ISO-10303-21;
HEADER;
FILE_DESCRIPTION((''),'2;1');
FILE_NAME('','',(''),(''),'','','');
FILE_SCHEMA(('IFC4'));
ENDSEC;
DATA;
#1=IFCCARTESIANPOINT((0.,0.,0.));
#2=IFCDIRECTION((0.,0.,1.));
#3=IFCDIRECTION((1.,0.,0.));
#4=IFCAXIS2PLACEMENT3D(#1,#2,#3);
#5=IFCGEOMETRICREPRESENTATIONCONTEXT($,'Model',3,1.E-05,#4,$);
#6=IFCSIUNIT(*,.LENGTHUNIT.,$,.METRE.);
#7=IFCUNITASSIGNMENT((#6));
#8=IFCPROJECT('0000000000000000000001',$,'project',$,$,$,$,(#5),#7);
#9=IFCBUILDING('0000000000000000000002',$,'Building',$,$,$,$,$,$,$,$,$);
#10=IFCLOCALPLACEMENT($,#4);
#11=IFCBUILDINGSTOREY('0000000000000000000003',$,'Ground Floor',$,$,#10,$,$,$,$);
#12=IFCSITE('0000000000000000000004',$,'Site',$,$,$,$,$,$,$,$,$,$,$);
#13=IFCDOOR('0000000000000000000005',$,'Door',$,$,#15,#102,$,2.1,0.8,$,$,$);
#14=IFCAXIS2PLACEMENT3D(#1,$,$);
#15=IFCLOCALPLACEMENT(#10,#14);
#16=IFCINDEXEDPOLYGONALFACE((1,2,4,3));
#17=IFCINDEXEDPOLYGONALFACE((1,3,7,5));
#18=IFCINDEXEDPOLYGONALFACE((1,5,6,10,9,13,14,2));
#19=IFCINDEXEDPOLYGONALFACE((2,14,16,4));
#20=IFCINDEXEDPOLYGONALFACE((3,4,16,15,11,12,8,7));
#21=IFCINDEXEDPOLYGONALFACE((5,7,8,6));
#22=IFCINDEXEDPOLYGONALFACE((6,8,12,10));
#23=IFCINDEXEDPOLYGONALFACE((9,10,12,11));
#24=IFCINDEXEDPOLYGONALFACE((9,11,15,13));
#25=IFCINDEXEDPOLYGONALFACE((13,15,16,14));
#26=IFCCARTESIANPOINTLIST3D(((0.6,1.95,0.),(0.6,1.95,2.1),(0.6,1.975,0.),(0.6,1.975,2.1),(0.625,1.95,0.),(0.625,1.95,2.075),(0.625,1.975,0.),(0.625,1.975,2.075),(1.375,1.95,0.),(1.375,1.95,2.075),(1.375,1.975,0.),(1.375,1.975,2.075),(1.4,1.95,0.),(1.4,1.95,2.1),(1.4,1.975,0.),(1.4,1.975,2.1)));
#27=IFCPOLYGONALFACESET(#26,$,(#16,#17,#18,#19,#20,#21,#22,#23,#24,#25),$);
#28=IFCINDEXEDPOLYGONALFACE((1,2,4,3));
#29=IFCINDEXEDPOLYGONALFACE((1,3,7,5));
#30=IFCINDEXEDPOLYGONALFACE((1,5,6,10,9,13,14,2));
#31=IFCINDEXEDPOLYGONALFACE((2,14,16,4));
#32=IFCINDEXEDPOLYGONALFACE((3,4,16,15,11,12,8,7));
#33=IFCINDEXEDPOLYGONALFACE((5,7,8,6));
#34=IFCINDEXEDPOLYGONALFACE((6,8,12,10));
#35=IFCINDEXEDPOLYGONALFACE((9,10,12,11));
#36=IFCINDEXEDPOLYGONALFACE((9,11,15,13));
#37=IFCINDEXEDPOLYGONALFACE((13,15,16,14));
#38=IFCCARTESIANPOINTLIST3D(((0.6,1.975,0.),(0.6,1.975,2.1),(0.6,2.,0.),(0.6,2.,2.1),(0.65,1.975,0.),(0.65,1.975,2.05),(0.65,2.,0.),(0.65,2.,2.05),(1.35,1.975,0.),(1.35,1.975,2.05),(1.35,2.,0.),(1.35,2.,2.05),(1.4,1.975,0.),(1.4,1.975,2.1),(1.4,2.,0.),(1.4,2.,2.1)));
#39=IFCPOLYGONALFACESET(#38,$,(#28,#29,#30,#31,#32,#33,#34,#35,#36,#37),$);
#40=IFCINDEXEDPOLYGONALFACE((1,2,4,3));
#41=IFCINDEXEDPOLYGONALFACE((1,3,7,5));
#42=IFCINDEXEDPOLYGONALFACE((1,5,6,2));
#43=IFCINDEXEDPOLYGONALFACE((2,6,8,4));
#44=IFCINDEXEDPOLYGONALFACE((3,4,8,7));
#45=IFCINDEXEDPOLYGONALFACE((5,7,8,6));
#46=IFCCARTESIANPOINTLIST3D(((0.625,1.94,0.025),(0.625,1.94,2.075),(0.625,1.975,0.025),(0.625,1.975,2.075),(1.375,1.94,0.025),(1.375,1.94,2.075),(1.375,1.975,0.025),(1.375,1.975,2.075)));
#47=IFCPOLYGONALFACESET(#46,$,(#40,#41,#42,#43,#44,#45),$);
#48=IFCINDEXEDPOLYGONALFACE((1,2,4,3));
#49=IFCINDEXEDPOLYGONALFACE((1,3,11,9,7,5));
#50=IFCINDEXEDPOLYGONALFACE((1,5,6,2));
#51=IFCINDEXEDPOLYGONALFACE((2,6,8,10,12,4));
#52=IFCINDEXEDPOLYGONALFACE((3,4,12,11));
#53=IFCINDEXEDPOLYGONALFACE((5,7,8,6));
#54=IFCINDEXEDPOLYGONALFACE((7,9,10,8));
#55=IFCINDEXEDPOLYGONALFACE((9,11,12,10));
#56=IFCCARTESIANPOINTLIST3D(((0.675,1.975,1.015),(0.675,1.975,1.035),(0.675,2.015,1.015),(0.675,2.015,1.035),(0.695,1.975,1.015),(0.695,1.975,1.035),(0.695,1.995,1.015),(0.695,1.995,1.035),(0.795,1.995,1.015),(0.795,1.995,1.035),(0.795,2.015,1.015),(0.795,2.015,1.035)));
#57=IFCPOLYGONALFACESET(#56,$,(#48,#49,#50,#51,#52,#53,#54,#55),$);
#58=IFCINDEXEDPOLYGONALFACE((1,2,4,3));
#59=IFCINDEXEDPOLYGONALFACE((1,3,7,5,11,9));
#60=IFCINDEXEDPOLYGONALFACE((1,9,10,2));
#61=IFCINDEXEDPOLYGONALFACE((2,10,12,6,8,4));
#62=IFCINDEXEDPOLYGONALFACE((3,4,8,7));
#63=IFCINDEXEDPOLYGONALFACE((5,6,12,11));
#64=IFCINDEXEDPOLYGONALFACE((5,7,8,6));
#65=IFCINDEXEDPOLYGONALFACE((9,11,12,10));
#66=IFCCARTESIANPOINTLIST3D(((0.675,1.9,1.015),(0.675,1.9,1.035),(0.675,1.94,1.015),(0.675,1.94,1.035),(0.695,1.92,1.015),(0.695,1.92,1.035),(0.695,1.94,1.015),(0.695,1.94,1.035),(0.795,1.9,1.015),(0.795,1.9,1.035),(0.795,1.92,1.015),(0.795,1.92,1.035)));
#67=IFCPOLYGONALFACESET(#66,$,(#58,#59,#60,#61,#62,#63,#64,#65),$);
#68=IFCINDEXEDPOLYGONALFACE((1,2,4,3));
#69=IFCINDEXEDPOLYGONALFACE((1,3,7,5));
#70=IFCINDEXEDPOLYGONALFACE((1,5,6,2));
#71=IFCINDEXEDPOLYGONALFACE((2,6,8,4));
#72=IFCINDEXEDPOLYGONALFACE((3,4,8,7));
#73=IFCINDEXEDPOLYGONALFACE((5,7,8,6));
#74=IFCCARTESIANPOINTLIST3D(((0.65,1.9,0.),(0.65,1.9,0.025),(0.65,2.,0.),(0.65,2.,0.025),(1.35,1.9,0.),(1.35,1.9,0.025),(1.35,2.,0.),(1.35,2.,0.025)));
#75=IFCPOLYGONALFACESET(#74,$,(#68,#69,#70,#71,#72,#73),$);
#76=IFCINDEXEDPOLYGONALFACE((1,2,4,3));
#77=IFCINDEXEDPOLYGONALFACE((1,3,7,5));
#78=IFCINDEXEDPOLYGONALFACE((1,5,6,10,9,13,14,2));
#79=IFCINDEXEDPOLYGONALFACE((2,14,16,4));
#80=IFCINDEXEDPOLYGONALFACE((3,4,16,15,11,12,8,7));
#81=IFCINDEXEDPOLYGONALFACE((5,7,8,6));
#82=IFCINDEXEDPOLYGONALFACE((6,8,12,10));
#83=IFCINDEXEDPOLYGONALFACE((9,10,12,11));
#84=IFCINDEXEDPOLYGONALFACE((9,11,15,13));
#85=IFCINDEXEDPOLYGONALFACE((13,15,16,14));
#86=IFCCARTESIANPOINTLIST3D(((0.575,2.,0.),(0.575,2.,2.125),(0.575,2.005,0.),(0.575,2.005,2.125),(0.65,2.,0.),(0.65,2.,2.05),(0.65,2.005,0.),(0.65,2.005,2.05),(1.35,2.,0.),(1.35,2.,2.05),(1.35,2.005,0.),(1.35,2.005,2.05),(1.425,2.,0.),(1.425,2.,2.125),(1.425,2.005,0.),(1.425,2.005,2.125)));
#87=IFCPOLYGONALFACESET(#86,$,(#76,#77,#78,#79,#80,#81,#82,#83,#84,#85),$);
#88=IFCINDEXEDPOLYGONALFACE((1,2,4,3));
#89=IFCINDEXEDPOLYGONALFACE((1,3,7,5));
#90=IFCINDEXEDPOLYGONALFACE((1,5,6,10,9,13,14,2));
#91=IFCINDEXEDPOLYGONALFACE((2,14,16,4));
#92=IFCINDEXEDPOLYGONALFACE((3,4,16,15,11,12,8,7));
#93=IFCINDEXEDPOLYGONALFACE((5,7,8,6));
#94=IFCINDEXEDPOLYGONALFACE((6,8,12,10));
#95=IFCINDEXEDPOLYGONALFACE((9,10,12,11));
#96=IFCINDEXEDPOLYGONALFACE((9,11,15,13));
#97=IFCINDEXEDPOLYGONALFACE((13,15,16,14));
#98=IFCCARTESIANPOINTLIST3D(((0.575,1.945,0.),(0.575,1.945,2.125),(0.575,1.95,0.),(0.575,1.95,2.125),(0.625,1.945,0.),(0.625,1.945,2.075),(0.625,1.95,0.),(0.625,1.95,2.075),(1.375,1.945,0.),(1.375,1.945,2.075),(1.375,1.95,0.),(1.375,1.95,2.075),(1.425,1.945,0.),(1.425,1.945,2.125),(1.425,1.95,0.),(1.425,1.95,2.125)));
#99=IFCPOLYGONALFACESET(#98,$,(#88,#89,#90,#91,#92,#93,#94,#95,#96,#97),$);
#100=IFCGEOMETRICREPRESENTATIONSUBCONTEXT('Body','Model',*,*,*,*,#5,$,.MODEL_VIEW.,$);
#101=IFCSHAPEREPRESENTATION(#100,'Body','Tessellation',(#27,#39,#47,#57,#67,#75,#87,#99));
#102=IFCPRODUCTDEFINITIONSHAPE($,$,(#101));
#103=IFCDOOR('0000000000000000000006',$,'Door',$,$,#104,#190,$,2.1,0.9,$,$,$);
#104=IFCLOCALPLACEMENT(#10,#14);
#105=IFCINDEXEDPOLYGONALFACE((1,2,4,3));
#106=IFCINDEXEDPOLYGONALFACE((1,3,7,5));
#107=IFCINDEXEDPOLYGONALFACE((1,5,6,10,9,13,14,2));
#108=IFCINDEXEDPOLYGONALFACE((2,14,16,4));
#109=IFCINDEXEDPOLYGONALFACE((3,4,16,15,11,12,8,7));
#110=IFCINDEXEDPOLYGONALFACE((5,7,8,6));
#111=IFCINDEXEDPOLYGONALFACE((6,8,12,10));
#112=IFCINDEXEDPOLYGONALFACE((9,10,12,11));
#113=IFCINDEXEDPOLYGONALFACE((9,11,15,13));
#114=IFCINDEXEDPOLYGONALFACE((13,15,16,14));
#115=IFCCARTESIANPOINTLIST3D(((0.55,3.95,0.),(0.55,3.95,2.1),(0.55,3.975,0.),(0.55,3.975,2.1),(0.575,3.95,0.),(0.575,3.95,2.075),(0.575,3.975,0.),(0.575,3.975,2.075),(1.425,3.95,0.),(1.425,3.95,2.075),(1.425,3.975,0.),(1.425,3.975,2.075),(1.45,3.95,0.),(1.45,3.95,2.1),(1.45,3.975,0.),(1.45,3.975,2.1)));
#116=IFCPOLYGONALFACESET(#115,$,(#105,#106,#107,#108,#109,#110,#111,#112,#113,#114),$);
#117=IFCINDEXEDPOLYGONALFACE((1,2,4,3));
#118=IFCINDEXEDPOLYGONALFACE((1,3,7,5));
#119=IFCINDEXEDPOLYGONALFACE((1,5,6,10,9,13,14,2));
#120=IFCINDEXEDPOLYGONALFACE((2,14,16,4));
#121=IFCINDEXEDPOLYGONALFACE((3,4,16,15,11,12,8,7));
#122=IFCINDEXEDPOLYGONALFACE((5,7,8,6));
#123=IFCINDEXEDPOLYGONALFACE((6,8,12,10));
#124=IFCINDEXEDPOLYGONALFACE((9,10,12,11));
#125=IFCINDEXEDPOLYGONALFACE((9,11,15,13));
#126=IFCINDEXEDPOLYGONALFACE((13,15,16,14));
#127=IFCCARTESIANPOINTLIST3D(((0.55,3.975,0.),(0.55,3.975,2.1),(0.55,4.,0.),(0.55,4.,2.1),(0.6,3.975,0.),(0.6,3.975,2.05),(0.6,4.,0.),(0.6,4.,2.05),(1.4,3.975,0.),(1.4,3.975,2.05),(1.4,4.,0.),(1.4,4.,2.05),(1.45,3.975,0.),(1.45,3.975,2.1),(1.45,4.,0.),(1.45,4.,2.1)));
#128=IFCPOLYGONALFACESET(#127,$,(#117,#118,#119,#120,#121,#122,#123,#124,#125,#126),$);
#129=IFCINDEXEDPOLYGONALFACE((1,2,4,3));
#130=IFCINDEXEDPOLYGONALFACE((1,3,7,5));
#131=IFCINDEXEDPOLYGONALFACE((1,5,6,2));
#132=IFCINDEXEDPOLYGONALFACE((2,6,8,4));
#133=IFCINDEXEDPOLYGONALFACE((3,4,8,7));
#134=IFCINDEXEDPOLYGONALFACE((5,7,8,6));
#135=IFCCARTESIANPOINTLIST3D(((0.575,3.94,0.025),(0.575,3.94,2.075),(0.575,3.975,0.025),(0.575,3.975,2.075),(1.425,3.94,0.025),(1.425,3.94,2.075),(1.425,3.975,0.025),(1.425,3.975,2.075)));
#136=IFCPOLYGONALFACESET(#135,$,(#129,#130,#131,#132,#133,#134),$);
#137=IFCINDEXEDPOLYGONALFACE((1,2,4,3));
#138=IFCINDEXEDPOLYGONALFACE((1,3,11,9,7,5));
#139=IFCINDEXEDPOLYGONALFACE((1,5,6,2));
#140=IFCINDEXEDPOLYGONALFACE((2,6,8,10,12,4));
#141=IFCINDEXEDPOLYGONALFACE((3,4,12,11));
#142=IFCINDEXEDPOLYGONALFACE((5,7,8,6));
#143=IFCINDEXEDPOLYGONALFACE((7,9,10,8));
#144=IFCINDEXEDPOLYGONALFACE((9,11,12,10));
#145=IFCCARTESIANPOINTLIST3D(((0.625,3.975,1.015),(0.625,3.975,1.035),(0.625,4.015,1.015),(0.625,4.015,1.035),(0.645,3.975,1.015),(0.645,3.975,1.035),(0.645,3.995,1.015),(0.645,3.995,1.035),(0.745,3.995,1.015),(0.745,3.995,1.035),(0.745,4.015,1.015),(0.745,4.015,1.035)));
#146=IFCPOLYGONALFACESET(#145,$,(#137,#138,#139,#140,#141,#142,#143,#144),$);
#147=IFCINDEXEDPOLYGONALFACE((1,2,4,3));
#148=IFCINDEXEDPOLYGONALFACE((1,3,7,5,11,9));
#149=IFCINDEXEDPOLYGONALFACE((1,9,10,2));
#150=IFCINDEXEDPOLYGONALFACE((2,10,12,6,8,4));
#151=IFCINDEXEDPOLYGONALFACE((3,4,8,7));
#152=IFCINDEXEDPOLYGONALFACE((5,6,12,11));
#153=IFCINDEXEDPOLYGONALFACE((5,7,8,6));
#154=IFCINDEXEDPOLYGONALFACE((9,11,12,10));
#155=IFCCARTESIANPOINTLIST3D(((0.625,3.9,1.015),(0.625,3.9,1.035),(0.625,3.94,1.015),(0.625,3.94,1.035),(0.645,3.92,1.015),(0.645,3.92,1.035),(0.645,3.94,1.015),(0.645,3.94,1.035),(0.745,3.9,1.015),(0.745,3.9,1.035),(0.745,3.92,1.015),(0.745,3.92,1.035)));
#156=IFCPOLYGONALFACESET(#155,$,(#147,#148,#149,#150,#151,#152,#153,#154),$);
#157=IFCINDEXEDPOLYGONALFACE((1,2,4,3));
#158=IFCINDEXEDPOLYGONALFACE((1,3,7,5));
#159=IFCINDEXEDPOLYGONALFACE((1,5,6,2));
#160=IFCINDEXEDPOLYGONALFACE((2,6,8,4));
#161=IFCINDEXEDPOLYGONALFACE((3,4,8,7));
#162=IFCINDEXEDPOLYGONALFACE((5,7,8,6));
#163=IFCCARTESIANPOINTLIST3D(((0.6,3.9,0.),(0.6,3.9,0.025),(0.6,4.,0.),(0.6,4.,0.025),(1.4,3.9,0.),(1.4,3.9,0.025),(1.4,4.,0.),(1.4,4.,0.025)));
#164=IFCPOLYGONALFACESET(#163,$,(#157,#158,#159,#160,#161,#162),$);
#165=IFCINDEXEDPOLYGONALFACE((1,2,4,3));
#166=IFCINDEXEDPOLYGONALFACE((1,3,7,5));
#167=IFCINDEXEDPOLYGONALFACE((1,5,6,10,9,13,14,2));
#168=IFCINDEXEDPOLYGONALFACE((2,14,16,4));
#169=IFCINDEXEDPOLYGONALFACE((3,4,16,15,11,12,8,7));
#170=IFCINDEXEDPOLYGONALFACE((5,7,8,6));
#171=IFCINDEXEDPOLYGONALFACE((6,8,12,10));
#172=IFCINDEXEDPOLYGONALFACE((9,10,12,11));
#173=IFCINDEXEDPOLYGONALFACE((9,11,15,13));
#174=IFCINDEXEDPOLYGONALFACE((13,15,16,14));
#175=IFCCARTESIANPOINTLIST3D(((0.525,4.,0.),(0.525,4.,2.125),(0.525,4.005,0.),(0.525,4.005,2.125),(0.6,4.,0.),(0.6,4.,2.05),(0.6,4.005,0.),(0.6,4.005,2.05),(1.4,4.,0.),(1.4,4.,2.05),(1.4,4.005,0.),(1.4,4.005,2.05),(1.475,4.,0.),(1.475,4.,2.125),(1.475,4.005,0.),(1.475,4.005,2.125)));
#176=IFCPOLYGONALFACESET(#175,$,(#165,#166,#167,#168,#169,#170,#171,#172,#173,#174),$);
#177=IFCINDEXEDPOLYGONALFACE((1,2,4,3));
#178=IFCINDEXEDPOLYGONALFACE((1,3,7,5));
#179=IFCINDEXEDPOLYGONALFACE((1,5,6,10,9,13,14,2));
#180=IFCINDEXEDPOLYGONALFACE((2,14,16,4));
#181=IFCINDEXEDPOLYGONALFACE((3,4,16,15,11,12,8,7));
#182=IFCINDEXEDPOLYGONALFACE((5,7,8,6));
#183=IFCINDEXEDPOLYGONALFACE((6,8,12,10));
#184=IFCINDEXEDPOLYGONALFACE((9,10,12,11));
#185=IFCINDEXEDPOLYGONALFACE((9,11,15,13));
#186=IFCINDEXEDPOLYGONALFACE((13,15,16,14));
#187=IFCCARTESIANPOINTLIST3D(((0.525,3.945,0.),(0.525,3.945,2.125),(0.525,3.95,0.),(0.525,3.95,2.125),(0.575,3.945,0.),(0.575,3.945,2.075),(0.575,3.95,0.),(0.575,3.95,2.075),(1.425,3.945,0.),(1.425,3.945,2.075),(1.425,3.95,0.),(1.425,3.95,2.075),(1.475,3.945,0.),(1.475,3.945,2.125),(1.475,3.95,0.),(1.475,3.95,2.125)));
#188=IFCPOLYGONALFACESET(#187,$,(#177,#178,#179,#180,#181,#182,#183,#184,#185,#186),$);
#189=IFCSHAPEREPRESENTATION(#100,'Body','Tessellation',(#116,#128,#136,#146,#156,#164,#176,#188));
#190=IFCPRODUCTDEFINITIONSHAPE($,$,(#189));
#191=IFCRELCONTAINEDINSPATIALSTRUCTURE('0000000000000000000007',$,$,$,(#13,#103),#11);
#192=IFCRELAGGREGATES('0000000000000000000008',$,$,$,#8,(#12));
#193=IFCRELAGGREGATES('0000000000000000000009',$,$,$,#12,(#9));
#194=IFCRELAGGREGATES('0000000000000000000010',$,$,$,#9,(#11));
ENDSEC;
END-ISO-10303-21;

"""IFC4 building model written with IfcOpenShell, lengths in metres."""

from ifc_helpers import new_model, si_unit, frame, origin_with_axes, place, context, subcontext, project, spatial, line, indexed_curve, outline, extrude, element, save


model = new_model("IFC4")

# Units and contexts
model_context = context("Model", 3, precision=1e-05, world=origin_with_axes())
body_context = subcontext(model_context, "Body", "Model", "MODEL_VIEW")
ifc_project = project(units=[si_unit("LENGTHUNIT", "METRE")], contexts=[model_context])

# Site, building, storey
site = spatial("IfcSite", under=ifc_project, Name="Site")
building = spatial("IfcBuilding", under=site, Name="Building")
storey_placement = place(None, origin_with_axes())
storey = spatial("IfcBuildingStorey", under=building, at=storey_placement, Name="Ground Floor")

# Doors
door_1_placement = place(storey_placement, frame((1.4, 2.0, 0.0), z_axis=(0.0, 0.0, 1.0), x_axis=(-1.0, 0.0, 0.0)))
element("IfcDoor", 1, at=door_1_placement, inside=storey, Name="Door", OverallHeight=2.1, OverallWidth=0.8, context=body_context, shape_type="SweptSolid", body=[
    extrude(outline(indexed_curve([(0.0, 0.0), (0.0, 2.1), (0.8, 2.1), (0.8, 0.0), (0.775, 0.0), (0.775, 2.075), (0.025, 2.075), (0.025, 0.0)], segments=[line(1, 2, 3, 4, 5, 6, 7, 8, 1)])), frame((0.0, 0.025, 0.0), z_axis=(0.0, -1.0, 0.0), x_axis=(1.0, 0.0, 0.0)), (0.0, 0.0, -1.0), 0.025),
    extrude(outline(indexed_curve([(0.0, 0.0), (0.0, 2.1), (0.8, 2.1), (0.8, 0.0), (0.75, 0.0), (0.75, 2.05), (0.05, 2.05), (0.05, 0.0)], segments=[line(1, 2, 3, 4, 5, 6, 7, 8, 1)])), frame((0.0, 0.0, 0.0), z_axis=(0.0, -1.0, 0.0), x_axis=(1.0, 0.0, 0.0)), (0.0, 0.0, -1.0), 0.025),
    extrude(outline(indexed_curve([(0.0, 0.0), (0.75, 0.0), (0.75, 0.035), (0.0, 0.035)], segments=[line(1, 2, 3, 4, 1)])), frame((0.025, 0.025, 0.025), z_axis=(0.0, 0.0, 1.0), x_axis=(1.0, 0.0, 0.0)), (0.0, 0.0, 1.0), 2.05),
    extrude(outline(indexed_curve([(0.0, 0.0), (0.0, -0.04), (-0.12, -0.04), (-0.12, -0.02), (-0.02, -0.02), (-0.02, 0.0)], segments=[line(1, 2, 3, 4, 5, 6, 1)])), frame((0.725, 0.025, 1.015), z_axis=(0.0, 0.0, 1.0), x_axis=(1.0, 0.0, 0.0)), (0.0, 0.0, 1.0), 0.02),
    extrude(outline(indexed_curve([(0.0, 0.0), (0.0, 0.04), (-0.12, 0.04), (-0.12, 0.02), (-0.02, 0.02), (-0.02, 0.0)], segments=[line(1, 2, 3, 4, 5, 6, 1)])), frame((0.725, 0.06, 1.015), z_axis=(0.0, 0.0, 1.0), x_axis=(1.0, 0.0, 0.0)), (0.0, 0.0, 1.0), 0.02),
    extrude(outline(indexed_curve([(0.0, 0.0), (0.7, 0.0), (0.7, 0.1), (0.0, 0.1)], segments=[line(1, 2, 3, 4, 1)])), frame((0.05, 0.0, 0.0), z_axis=(0.0, 0.0, 1.0), x_axis=(1.0, 0.0, 0.0)), (0.0, 0.0, 1.0), 0.025),
    extrude(outline(indexed_curve([(0.0, 0.0), (0.0, 2.125), (0.85, 2.125), (0.85, 0.0), (0.775, 0.0), (0.775, 2.05), (0.075, 2.05), (0.075, 0.0)], segments=[line(1, 2, 3, 4, 5, 6, 7, 8, 1)])), frame((-0.025, -0.005, 0.0), z_axis=(0.0, -1.0, 0.0), x_axis=(1.0, 0.0, 0.0)), (0.0, 0.0, -1.0), 0.005),
    extrude(outline(indexed_curve([(0.0, 0.0), (0.0, 2.125), (0.85, 2.125), (0.85, 0.0), (0.8, 0.0), (0.8, 2.075), (0.05, 2.075), (0.05, 0.0)], segments=[line(1, 2, 3, 4, 5, 6, 7, 8, 1)])), frame((-0.025, 0.05, 0.0), z_axis=(0.0, -1.0, 0.0), x_axis=(1.0, 0.0, 0.0)), (0.0, 0.0, -1.0), 0.005),
])
door_2_placement = place(storey_placement, frame((1.45, 4.0, 0.0), z_axis=(0.0, 0.0, 1.0), x_axis=(-1.0, 0.0, 0.0)))
element("IfcDoor", 2, at=door_2_placement, inside=storey, Name="Door", OverallHeight=2.1, OverallWidth=0.9, context=body_context, shape_type="SweptSolid", body=[
    extrude(outline(indexed_curve([(0.0, 0.0), (0.0, 2.1), (0.9, 2.1), (0.9, 0.0), (0.875, 0.0), (0.875, 2.075), (0.025, 2.075), (0.025, 0.0)], segments=[line(1, 2, 3, 4, 5, 6, 7, 8, 1)])), frame((0.0, 0.025, 0.0), z_axis=(0.0, -1.0, 0.0), x_axis=(1.0, 0.0, 0.0)), (0.0, 0.0, -1.0), 0.025),
    extrude(outline(indexed_curve([(0.0, 0.0), (0.0, 2.1), (0.9, 2.1), (0.9, 0.0), (0.85, 0.0), (0.85, 2.05), (0.05, 2.05), (0.05, 0.0)], segments=[line(1, 2, 3, 4, 5, 6, 7, 8, 1)])), frame((0.0, 0.0, 0.0), z_axis=(0.0, -1.0, 0.0), x_axis=(1.0, 0.0, 0.0)), (0.0, 0.0, -1.0), 0.025),
    extrude(outline(indexed_curve([(0.0, 0.0), (0.85, 0.0), (0.85, 0.035), (0.0, 0.035)], segments=[line(1, 2, 3, 4, 1)])), frame((0.025, 0.025, 0.025), z_axis=(0.0, 0.0, 1.0), x_axis=(1.0, 0.0, 0.0)), (0.0, 0.0, 1.0), 2.05),
    extrude(outline(indexed_curve([(0.0, 0.0), (0.0, -0.04), (-0.12, -0.04), (-0.12, -0.02), (-0.02, -0.02), (-0.02, 0.0)], segments=[line(1, 2, 3, 4, 5, 6, 1)])), frame((0.825, 0.025, 1.015), z_axis=(0.0, 0.0, 1.0), x_axis=(1.0, 0.0, 0.0)), (0.0, 0.0, 1.0), 0.02),
    extrude(outline(indexed_curve([(0.0, 0.0), (0.0, 0.04), (-0.12, 0.04), (-0.12, 0.02), (-0.02, 0.02), (-0.02, 0.0)], segments=[line(1, 2, 3, 4, 5, 6, 1)])), frame((0.825, 0.06, 1.015), z_axis=(0.0, 0.0, 1.0), x_axis=(1.0, 0.0, 0.0)), (0.0, 0.0, 1.0), 0.02),
    extrude(outline(indexed_curve([(0.0, 0.0), (0.8, 0.0), (0.8, 0.1), (0.0, 0.1)], segments=[line(1, 2, 3, 4, 1)])), frame((0.05, 0.0, 0.0), z_axis=(0.0, 0.0, 1.0), x_axis=(1.0, 0.0, 0.0)), (0.0, 0.0, 1.0), 0.025),
    extrude(outline(indexed_curve([(0.0, 0.0), (0.0, 2.125), (0.95, 2.125), (0.95, 0.0), (0.875, 0.0), (0.875, 2.05), (0.075, 2.05), (0.075, 0.0)], segments=[line(1, 2, 3, 4, 5, 6, 7, 8, 1)])), frame((-0.025, -0.005, 0.0), z_axis=(0.0, -1.0, 0.0), x_axis=(1.0, 0.0, 0.0)), (0.0, 0.0, -1.0), 0.005),
    extrude(outline(indexed_curve([(0.0, 0.0), (0.0, 2.125), (0.95, 2.125), (0.95, 0.0), (0.9, 0.0), (0.9, 2.075), (0.05, 2.075), (0.05, 0.0)], segments=[line(1, 2, 3, 4, 5, 6, 7, 8, 1)])), frame((-0.025, 0.05, 0.0), z_axis=(0.0, -1.0, 0.0), x_axis=(1.0, 0.0, 0.0)), (0.0, 0.0, -1.0), 0.005),
])

save(model, "model.ifc")
